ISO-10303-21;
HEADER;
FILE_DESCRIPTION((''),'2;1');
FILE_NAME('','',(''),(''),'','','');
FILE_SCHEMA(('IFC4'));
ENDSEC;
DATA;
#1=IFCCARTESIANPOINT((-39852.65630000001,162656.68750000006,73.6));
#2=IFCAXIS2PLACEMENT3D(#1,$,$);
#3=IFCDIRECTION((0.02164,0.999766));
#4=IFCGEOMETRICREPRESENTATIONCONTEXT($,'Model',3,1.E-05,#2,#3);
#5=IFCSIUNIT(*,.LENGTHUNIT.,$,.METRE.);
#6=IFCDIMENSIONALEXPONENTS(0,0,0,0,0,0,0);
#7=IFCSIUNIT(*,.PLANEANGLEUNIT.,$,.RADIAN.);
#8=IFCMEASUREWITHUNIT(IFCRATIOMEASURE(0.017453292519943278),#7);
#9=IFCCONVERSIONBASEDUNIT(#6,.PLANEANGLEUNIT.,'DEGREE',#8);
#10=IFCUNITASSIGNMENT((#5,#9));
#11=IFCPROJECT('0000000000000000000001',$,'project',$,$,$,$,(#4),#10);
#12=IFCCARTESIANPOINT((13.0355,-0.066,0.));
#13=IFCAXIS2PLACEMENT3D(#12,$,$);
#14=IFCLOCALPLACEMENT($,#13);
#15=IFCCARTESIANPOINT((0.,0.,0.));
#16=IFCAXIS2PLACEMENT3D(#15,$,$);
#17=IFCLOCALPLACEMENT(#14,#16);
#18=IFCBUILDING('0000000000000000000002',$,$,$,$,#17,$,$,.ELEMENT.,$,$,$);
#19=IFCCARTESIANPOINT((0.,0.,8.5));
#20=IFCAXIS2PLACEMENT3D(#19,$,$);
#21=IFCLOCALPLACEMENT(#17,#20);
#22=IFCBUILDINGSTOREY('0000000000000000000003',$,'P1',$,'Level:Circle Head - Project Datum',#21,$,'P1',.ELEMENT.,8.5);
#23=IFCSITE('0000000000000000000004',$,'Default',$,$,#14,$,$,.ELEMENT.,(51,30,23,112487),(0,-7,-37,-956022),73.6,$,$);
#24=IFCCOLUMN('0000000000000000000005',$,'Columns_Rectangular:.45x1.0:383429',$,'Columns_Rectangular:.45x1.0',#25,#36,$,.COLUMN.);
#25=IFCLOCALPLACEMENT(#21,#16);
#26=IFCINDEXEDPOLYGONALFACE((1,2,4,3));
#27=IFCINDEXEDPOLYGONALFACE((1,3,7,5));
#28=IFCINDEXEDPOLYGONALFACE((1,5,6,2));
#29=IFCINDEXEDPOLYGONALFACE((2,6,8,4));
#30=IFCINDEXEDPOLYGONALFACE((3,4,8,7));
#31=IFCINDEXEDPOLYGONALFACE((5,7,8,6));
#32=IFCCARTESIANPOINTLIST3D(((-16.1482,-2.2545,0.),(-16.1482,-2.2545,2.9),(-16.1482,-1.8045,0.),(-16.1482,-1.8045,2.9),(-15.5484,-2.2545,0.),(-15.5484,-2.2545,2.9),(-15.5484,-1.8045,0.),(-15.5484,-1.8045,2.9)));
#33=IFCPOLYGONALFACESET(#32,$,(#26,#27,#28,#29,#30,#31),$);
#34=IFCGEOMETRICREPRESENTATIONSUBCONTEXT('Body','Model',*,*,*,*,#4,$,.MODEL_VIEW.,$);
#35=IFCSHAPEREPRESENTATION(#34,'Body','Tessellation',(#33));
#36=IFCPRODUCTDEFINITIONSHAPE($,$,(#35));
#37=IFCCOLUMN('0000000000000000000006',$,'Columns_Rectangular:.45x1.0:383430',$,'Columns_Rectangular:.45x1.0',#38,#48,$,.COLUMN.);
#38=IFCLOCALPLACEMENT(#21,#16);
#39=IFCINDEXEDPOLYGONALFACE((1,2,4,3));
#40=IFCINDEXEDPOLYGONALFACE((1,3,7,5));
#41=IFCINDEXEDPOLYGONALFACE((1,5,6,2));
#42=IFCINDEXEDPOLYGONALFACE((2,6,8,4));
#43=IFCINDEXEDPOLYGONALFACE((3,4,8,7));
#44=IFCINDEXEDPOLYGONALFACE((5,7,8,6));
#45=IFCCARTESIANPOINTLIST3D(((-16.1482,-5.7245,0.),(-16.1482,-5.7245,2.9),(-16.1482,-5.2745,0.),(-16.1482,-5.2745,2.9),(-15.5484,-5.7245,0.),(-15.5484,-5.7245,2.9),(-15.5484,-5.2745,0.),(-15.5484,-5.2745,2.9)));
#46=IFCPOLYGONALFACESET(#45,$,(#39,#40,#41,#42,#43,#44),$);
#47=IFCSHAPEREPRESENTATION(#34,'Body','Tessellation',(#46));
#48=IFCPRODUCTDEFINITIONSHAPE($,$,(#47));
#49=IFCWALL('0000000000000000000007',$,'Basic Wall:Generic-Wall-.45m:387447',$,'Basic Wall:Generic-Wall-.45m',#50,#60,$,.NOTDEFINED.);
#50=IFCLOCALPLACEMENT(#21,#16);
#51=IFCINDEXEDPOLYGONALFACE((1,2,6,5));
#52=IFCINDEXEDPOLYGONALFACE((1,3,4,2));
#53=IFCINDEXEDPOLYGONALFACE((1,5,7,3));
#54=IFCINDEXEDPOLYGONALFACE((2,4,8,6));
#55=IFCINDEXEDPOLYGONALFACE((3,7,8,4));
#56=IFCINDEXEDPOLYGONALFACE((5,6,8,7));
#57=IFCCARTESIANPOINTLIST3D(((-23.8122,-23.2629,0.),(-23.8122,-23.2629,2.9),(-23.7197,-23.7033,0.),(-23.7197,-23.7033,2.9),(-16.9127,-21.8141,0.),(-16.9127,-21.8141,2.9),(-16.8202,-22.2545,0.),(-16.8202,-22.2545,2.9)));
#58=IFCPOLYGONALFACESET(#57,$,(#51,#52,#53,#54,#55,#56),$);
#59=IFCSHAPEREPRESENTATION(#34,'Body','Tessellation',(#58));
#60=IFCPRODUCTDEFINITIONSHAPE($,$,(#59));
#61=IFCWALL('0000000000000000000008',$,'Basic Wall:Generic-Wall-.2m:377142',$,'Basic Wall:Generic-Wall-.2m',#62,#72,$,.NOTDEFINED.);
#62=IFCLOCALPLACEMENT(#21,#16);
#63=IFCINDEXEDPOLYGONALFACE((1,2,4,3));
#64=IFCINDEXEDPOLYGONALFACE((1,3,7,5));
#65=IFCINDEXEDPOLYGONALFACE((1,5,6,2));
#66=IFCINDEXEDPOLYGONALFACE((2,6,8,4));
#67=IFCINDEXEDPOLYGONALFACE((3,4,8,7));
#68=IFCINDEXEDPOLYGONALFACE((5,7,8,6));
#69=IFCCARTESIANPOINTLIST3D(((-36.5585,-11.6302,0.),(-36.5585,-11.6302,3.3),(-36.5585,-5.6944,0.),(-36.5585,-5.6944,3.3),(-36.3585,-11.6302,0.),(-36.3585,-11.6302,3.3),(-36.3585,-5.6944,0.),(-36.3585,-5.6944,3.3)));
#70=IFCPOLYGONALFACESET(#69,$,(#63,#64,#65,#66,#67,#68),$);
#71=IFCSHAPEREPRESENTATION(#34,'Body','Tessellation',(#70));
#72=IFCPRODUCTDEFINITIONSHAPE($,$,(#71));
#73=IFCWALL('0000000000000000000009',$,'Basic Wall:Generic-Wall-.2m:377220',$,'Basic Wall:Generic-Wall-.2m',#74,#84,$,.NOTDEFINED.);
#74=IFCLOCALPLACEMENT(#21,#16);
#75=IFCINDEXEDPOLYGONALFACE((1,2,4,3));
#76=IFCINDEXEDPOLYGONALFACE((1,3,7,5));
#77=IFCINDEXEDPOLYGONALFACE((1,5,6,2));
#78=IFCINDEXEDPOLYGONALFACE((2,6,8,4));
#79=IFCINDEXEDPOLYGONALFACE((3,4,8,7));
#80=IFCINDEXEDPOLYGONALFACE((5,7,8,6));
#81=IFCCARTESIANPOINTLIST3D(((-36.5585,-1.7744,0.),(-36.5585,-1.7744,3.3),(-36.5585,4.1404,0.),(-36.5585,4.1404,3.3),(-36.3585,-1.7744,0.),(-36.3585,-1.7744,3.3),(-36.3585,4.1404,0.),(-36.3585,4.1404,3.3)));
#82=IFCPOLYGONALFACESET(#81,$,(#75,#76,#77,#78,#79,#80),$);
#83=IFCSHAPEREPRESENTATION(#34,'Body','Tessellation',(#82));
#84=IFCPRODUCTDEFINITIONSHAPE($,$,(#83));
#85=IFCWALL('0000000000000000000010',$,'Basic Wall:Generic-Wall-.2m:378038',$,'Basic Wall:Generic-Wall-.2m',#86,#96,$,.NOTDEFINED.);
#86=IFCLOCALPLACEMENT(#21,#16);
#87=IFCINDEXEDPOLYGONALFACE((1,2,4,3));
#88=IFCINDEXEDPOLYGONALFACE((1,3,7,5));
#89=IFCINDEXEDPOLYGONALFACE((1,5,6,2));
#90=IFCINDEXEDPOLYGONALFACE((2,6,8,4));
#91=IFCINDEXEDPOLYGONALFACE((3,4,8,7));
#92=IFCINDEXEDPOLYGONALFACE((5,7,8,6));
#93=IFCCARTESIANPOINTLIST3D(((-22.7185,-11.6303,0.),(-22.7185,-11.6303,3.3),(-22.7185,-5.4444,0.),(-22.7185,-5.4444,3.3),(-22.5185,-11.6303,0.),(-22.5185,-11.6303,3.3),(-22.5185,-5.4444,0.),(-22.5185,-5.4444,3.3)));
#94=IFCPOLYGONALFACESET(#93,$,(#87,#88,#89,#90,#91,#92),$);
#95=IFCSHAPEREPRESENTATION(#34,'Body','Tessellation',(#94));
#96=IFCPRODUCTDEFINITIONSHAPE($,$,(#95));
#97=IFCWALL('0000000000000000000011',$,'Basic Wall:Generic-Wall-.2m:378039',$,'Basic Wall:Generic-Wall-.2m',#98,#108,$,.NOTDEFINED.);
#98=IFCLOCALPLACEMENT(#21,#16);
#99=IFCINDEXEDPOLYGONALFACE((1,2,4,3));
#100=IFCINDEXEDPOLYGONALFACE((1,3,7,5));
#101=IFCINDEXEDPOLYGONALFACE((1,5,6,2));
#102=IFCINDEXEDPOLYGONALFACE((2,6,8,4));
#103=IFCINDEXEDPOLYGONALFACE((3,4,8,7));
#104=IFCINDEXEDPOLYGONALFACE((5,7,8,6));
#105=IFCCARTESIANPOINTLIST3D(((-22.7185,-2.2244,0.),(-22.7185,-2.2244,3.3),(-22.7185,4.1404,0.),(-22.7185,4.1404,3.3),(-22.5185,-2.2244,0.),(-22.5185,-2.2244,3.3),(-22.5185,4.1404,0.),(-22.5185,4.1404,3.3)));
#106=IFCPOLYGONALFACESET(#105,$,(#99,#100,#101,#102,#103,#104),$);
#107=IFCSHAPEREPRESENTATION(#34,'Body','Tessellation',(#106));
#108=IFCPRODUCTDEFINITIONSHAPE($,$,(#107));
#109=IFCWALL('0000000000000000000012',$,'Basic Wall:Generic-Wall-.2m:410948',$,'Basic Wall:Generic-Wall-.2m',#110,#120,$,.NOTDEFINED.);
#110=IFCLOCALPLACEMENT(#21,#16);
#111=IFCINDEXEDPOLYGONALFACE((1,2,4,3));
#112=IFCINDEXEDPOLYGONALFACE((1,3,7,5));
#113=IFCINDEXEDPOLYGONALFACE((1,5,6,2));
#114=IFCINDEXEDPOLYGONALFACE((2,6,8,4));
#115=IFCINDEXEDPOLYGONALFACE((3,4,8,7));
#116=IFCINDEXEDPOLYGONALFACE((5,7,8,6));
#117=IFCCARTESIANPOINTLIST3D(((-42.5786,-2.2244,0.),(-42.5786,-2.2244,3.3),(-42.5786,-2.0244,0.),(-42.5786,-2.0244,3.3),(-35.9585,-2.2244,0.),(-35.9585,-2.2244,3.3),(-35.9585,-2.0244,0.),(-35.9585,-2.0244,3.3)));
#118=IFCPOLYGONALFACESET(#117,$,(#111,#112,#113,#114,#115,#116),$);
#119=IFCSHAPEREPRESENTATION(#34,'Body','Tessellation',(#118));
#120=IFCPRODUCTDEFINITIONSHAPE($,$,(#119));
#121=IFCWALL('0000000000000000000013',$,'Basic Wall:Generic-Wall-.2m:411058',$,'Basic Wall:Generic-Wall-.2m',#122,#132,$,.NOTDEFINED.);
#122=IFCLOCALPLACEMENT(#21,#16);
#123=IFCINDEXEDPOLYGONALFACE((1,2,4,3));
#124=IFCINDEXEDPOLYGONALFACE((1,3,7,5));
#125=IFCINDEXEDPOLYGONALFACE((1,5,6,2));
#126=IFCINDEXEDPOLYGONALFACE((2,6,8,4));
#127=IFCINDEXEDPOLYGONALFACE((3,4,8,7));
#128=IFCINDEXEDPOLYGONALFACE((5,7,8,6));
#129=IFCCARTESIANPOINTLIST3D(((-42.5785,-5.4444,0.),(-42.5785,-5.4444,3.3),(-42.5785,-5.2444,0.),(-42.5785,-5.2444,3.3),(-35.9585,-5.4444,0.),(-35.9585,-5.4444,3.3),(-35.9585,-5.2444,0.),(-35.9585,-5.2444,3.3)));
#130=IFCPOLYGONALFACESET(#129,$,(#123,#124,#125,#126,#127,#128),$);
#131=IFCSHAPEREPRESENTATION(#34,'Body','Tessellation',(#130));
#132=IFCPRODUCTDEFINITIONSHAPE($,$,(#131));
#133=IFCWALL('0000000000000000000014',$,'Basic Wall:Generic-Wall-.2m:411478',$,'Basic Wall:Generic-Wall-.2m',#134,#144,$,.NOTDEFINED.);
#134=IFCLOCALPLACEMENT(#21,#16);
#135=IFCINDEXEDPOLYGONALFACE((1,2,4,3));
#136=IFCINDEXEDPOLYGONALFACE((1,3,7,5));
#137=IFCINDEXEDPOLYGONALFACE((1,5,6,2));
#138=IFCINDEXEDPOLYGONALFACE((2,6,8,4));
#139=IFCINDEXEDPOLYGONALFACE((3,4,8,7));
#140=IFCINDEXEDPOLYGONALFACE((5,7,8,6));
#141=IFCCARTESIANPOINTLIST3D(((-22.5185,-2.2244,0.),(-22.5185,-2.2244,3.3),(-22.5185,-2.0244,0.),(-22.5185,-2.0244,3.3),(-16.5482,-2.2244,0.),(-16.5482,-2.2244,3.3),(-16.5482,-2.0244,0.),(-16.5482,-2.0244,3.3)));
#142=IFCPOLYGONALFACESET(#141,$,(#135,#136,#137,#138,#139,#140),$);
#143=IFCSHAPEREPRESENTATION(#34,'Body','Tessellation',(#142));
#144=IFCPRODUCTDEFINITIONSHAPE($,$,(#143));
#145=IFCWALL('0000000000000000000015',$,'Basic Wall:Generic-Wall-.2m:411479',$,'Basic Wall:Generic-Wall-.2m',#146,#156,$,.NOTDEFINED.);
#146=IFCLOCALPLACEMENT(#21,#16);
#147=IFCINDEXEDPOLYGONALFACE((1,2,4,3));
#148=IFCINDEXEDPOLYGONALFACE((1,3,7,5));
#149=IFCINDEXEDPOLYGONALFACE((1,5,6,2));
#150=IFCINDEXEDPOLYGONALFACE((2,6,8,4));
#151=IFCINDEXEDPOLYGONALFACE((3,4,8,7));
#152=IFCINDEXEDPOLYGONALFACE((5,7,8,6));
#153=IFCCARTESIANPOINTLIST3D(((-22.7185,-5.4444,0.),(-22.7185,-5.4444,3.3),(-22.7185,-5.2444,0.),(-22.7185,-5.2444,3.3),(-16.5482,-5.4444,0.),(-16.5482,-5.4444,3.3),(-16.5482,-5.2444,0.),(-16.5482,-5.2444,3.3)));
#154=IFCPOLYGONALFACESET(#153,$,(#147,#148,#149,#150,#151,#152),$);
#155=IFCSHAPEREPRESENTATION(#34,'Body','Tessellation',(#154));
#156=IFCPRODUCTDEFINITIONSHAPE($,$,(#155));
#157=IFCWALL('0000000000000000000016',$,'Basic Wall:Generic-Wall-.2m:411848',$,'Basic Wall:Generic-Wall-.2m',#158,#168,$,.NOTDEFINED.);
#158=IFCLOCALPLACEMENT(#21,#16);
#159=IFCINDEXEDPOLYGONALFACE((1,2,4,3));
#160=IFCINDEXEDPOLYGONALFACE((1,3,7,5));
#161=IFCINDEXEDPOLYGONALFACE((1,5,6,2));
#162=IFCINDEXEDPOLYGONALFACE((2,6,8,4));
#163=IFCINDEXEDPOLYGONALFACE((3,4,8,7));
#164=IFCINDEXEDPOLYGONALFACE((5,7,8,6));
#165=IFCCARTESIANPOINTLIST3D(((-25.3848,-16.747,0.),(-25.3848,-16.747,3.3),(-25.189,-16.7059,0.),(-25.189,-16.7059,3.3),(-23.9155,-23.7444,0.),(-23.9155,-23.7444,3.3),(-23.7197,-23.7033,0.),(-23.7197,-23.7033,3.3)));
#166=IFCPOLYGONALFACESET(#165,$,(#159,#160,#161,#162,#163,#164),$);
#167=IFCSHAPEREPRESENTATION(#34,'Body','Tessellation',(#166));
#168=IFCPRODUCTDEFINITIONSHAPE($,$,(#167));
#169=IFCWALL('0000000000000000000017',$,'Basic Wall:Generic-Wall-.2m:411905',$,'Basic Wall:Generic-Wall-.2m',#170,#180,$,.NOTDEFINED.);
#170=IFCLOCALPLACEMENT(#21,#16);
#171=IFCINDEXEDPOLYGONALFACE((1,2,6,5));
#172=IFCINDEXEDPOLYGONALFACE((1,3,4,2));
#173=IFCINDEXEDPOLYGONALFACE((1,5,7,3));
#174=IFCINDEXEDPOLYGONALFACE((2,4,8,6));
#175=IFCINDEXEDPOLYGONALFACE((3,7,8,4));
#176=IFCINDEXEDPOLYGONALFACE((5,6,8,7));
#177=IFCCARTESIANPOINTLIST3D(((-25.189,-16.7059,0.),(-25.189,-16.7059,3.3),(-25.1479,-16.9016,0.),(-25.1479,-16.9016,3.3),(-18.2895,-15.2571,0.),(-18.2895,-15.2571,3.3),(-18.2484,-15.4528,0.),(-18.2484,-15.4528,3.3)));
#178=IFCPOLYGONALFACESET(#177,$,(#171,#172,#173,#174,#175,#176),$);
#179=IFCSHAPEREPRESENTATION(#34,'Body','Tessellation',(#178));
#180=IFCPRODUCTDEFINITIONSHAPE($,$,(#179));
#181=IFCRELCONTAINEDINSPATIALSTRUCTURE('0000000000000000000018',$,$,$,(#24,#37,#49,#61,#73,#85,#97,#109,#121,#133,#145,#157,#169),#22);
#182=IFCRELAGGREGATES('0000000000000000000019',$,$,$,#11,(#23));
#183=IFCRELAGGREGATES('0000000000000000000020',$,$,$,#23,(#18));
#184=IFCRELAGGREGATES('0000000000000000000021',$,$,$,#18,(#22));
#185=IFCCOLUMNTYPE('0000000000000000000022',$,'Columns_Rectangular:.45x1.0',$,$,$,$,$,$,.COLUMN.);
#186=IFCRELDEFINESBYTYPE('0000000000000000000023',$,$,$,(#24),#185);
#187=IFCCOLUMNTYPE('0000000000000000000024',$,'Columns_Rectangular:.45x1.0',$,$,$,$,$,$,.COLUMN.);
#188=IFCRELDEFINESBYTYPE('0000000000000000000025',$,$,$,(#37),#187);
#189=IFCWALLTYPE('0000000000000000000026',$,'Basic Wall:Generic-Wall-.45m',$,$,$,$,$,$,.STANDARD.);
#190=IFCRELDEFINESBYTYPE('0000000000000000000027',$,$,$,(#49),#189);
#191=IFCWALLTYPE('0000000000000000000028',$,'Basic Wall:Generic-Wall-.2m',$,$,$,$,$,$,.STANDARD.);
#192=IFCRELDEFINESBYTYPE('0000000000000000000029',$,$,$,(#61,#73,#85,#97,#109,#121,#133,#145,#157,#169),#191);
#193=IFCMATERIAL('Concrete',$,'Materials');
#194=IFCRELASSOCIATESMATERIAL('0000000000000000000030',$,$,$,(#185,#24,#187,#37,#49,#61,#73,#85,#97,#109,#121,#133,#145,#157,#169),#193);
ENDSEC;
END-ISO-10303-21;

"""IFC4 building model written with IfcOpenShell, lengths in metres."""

from ifc_helpers import new_model, entity, si_unit, converted_unit, direction, frame, origin, place, context, subcontext, project, spatial, indexed_curve, outline, extrude, source, transform, mapped, material, type_object, type_shapes, element, save


model = new_model("IFC4")

# Units and contexts
model_context = context("Model", 3, precision=1e-05, world=frame((-39852.65630000001, 162656.68750000006, 73.6)), true_north=direction((0.02164, 0.999766)))
body_context = subcontext(model_context, "Body", "Model", "MODEL_VIEW")
ifc_project = project(units=[si_unit("LENGTHUNIT", "METRE"), converted_unit("PLANEANGLEUNIT", "DEGREE", entity("IfcRatioMeasure", 0.017453292519943278), si_unit("PLANEANGLEUNIT", "RADIAN"), dimensions=[0, 0, 0, 0, 0, 0, 0])], contexts=[model_context])

# Site, building, storey
site_placement = place(None, frame((13.0355, -0.066, 0.0)))
site = spatial("IfcSite", under=ifc_project, at=site_placement, Name="Default", CompositionType="ELEMENT", RefLatitude=(51, 30, 23, 112487), RefLongitude=(0, -7, -37, -956022), RefElevation=73.6)
building_placement = place(site_placement, origin())
building = spatial("IfcBuilding", under=site, at=building_placement, CompositionType="ELEMENT")
storey_placement = place(building_placement, frame((0.0, 0.0, 8.5)))
storey = spatial("IfcBuildingStorey", under=building, at=storey_placement, Name="P1", ObjectType="Level:Circle Head - Project Datum", LongName="P1", CompositionType="ELEMENT", Elevation=8.5)

# Columns
ifc_material = material(Name="Concrete", Category="Materials")
column_type_1 = type_object("IfcColumnType", Name="Columns_Rectangular:.45x1.0", PredefinedType="COLUMN", material=ifc_material)
shared_shape_1 = source(origin(), body_context, "Body", "SweptSolid", [
    extrude(outline(indexed_curve([(-0.225, -0.2999), (0.225, -0.2999), (0.225, 0.2999), (-0.225, 0.2999), (-0.225, -0.2999)], self_intersect=False)), frame((-15.8483, -2.0295, 8.5), z_axis=(0.0, 0.0, 1.0), x_axis=(0.0, -1.0, 0.0)), (0.0, 0.0, 1.0), 2.9),
])
type_shapes(column_type_1, [shared_shape_1])
column_1_placement = place(storey_placement, frame((0.0, 0.0, -8.5)))
element("IfcColumn", 1, at=column_1_placement, inside=storey, type_object=column_type_1, material=ifc_material, Name="Columns_Rectangular:.45x1.0:383429", ObjectType="Columns_Rectangular:.45x1.0", PredefinedType="COLUMN", context=body_context, shape_type="MappedRepresentation", body=[
    mapped(shared_shape_1, transform((0.0, 0.0, 0.0), scale=1.0)),
])
column_type_2 = type_object("IfcColumnType", Name="Columns_Rectangular:.45x1.0", PredefinedType="COLUMN", material=ifc_material)
shared_shape_2 = source(origin(), body_context, "Body", "SweptSolid", [
    extrude(outline(indexed_curve([(-0.225, -0.2999), (0.225, -0.2999), (0.225, 0.2999), (-0.225, 0.2999), (-0.225, -0.2999)], self_intersect=False)), frame((-15.8483, -5.4995, 8.5), z_axis=(0.0, 0.0, 1.0), x_axis=(0.0, -1.0, 0.0)), (0.0, 0.0, 1.0), 2.9),
])
type_shapes(column_type_2, [shared_shape_2])
column_2_placement = place(storey_placement, frame((0.0, 0.0, -8.5)))
element("IfcColumn", 2, at=column_2_placement, inside=storey, type_object=column_type_2, material=ifc_material, Name="Columns_Rectangular:.45x1.0:383430", ObjectType="Columns_Rectangular:.45x1.0", PredefinedType="COLUMN", context=body_context, shape_type="MappedRepresentation", body=[
    mapped(shared_shape_2, transform((0.0, 0.0, 0.0), scale=1.0)),
])

# Walls
wall_type_1 = type_object("IfcWallType", Name="Basic Wall:Generic-Wall-.45m", PredefinedType="STANDARD")
wall_1_placement = place(storey_placement, frame((-23.766, -23.4831, 0.0), z_axis=(0.0, 0.0, 1.0), x_axis=(0.978657, 0.2055, 0.0)))
element("IfcWall", 3, at=wall_1_placement, inside=storey, type_object=wall_type_1, material=ifc_material, Name="Basic Wall:Generic-Wall-.45m:387447", ObjectType="Basic Wall:Generic-Wall-.45m", PredefinedType="NOTDEFINED", context=body_context, shape_type="SweptSolid", body=[
    extrude(outline(indexed_curve([(7.05, 0.225), (0.0, 0.225), (0.0, -0.225), (7.05, -0.225), (7.05, 0.225)], self_intersect=False)), origin(), (0.0, 0.0, 1.0), 2.9),
])
wall_type_2 = type_object("IfcWallType", Name="Basic Wall:Generic-Wall-.2m", PredefinedType="STANDARD")
wall_2_placement = place(storey_placement, frame((-36.4585, -5.6944, 0.0), z_axis=(0.0, 0.0, 1.0), x_axis=(0.0, -1.0, 0.0)))
element("IfcWall", 4, at=wall_2_placement, inside=storey, type_object=wall_type_2, material=ifc_material, Name="Basic Wall:Generic-Wall-.2m:377142", ObjectType="Basic Wall:Generic-Wall-.2m", PredefinedType="NOTDEFINED", context=body_context, shape_type="SweptSolid", body=[
    extrude(outline(indexed_curve([(5.9357, 0.1), (0.0, 0.1), (0.0, -0.1), (5.9357, -0.1), (5.9357, 0.1)], self_intersect=False)), origin(), (0.0, 0.0, 1.0), 3.3),
])
wall_3_placement = place(storey_placement, frame((-36.4585, -1.7744, 0.0), z_axis=(0.0, 0.0, 1.0), x_axis=(0.0, 1.0, 0.0)))
element("IfcWall", 5, at=wall_3_placement, inside=storey, type_object=wall_type_2, material=ifc_material, Name="Basic Wall:Generic-Wall-.2m:377220", ObjectType="Basic Wall:Generic-Wall-.2m", PredefinedType="NOTDEFINED", context=body_context, shape_type="SweptSolid", body=[
    extrude(outline(indexed_curve([(5.9149, 0.1), (0.0, 0.1), (0.0, -0.1), (5.9149, -0.1), (5.9149, 0.1)], self_intersect=False)), origin(), (0.0, 0.0, 1.0), 3.3),
])
wall_4_placement = place(storey_placement, frame((-22.6185, -5.4444, 0.0), z_axis=(0.0, 0.0, 1.0), x_axis=(0.0, -1.0, 0.0)))
element("IfcWall", 6, at=wall_4_placement, inside=storey, type_object=wall_type_2, material=ifc_material, Name="Basic Wall:Generic-Wall-.2m:378038", ObjectType="Basic Wall:Generic-Wall-.2m", PredefinedType="NOTDEFINED", context=body_context, shape_type="SweptSolid", body=[
    extrude(outline(indexed_curve([(6.1859, 0.1), (0.0, 0.1), (0.0, -0.1), (6.1859, -0.1), (6.1859, 0.1)], self_intersect=False)), origin(), (0.0, 0.0, 1.0), 3.3),
])
wall_5_placement = place(storey_placement, frame((-22.6185, -2.2244, 0.0), z_axis=(0.0, 0.0, 1.0), x_axis=(0.0, 1.0, 0.0)))
element("IfcWall", 7, at=wall_5_placement, inside=storey, type_object=wall_type_2, material=ifc_material, Name="Basic Wall:Generic-Wall-.2m:378039", ObjectType="Basic Wall:Generic-Wall-.2m", PredefinedType="NOTDEFINED", context=body_context, shape_type="SweptSolid", body=[
    extrude(outline(indexed_curve([(6.3649, 0.1), (0.0, 0.1), (0.0, -0.1), (6.3649, -0.1), (6.3649, 0.1)], self_intersect=False)), origin(), (0.0, 0.0, 1.0), 3.3),
])
wall_6_placement = place(storey_placement, frame((-35.9585, -2.1244, 0.0), z_axis=(0.0, 0.0, 1.0), x_axis=(-1.0, 0.0, 0.0)))
element("IfcWall", 8, at=wall_6_placement, inside=storey, type_object=wall_type_2, material=ifc_material, Name="Basic Wall:Generic-Wall-.2m:410948", ObjectType="Basic Wall:Generic-Wall-.2m", PredefinedType="NOTDEFINED", context=body_context, shape_type="SweptSolid", body=[
    extrude(outline(indexed_curve([(6.6201, 0.1), (0.0, 0.1), (0.0, -0.1), (6.6201, -0.1), (6.6201, 0.1)], self_intersect=False)), origin(), (0.0, 0.0, 1.0), 3.3),
])
wall_7_placement = place(storey_placement, frame((-35.9585, -5.3444, 0.0), z_axis=(0.0, 0.0, 1.0), x_axis=(-1.0, 0.0, 0.0)))
element("IfcWall", 9, at=wall_7_placement, inside=storey, type_object=wall_type_2, material=ifc_material, Name="Basic Wall:Generic-Wall-.2m:411058", ObjectType="Basic Wall:Generic-Wall-.2m", PredefinedType="NOTDEFINED", context=body_context, shape_type="SweptSolid", body=[
    extrude(outline(indexed_curve([(6.6201, 0.1), (0.0, 0.1), (0.0, -0.1), (6.6201, -0.1), (6.6201, 0.1)], self_intersect=False)), origin(), (0.0, 0.0, 1.0), 3.3),
])
wall_8_placement = place(storey_placement, frame((-22.5185, -2.1244, 0.0)))
element("IfcWall", 10, at=wall_8_placement, inside=storey, type_object=wall_type_2, material=ifc_material, Name="Basic Wall:Generic-Wall-.2m:411478", ObjectType="Basic Wall:Generic-Wall-.2m", PredefinedType="NOTDEFINED", context=body_context, shape_type="SweptSolid", body=[
    extrude(outline(indexed_curve([(5.9702, 0.1), (0.0, 0.1), (0.0, -0.1), (5.9702, -0.1), (5.9702, 0.1)], self_intersect=False)), origin(), (0.0, 0.0, 1.0), 3.3),
])
wall_9_placement = place(storey_placement, frame((-22.7185, -5.3444, 0.0)))
element("IfcWall", 11, at=wall_9_placement, inside=storey, type_object=wall_type_2, material=ifc_material, Name="Basic Wall:Generic-Wall-.2m:411479", ObjectType="Basic Wall:Generic-Wall-.2m", PredefinedType="NOTDEFINED", context=body_context, shape_type="SweptSolid", body=[
    extrude(outline(indexed_curve([(6.1702, 0.1), (0.0, 0.1), (0.0, -0.1), (6.1702, -0.1), (6.1702, 0.1)], self_intersect=False)), origin(), (0.0, 0.0, 1.0), 3.3),
])
wall_10_placement = place(storey_placement, frame((-23.8176, -23.7238, 0.0), z_axis=(0.0, 0.0, 1.0), x_axis=(-0.2055, 0.978657, 0.0)))
element("IfcWall", 12, at=wall_10_placement, inside=storey, type_object=wall_type_2, material=ifc_material, Name="Basic Wall:Generic-Wall-.2m:411848", ObjectType="Basic Wall:Generic-Wall-.2m", PredefinedType="NOTDEFINED", context=body_context, shape_type="SweptSolid", body=[
    extrude(outline(indexed_curve([(7.15, 0.1), (0.0, 0.1), (0.0, -0.1), (7.15, -0.1), (7.15, 0.1)], self_intersect=False)), origin(), (0.0, 0.0, 1.0), 3.3),
])
wall_11_placement = place(storey_placement, frame((-25.1685, -16.8038, 0.0), z_axis=(0.0, 0.0, 1.0), x_axis=(0.978657, 0.2055, 0.0)))
element("IfcWall", 13, at=wall_11_placement, inside=storey, type_object=wall_type_2, material=ifc_material, Name="Basic Wall:Generic-Wall-.2m:411905", ObjectType="Basic Wall:Generic-Wall-.2m", PredefinedType="NOTDEFINED", context=body_context, shape_type="SweptSolid", body=[
    extrude(outline(indexed_curve([(7.05, 0.1), (0.0, 0.1), (0.0, -0.1), (7.05, -0.1), (7.05, 0.1)], self_intersect=False)), origin(), (0.0, 0.0, 1.0), 3.3),
])

save(model, "model.ifc")
